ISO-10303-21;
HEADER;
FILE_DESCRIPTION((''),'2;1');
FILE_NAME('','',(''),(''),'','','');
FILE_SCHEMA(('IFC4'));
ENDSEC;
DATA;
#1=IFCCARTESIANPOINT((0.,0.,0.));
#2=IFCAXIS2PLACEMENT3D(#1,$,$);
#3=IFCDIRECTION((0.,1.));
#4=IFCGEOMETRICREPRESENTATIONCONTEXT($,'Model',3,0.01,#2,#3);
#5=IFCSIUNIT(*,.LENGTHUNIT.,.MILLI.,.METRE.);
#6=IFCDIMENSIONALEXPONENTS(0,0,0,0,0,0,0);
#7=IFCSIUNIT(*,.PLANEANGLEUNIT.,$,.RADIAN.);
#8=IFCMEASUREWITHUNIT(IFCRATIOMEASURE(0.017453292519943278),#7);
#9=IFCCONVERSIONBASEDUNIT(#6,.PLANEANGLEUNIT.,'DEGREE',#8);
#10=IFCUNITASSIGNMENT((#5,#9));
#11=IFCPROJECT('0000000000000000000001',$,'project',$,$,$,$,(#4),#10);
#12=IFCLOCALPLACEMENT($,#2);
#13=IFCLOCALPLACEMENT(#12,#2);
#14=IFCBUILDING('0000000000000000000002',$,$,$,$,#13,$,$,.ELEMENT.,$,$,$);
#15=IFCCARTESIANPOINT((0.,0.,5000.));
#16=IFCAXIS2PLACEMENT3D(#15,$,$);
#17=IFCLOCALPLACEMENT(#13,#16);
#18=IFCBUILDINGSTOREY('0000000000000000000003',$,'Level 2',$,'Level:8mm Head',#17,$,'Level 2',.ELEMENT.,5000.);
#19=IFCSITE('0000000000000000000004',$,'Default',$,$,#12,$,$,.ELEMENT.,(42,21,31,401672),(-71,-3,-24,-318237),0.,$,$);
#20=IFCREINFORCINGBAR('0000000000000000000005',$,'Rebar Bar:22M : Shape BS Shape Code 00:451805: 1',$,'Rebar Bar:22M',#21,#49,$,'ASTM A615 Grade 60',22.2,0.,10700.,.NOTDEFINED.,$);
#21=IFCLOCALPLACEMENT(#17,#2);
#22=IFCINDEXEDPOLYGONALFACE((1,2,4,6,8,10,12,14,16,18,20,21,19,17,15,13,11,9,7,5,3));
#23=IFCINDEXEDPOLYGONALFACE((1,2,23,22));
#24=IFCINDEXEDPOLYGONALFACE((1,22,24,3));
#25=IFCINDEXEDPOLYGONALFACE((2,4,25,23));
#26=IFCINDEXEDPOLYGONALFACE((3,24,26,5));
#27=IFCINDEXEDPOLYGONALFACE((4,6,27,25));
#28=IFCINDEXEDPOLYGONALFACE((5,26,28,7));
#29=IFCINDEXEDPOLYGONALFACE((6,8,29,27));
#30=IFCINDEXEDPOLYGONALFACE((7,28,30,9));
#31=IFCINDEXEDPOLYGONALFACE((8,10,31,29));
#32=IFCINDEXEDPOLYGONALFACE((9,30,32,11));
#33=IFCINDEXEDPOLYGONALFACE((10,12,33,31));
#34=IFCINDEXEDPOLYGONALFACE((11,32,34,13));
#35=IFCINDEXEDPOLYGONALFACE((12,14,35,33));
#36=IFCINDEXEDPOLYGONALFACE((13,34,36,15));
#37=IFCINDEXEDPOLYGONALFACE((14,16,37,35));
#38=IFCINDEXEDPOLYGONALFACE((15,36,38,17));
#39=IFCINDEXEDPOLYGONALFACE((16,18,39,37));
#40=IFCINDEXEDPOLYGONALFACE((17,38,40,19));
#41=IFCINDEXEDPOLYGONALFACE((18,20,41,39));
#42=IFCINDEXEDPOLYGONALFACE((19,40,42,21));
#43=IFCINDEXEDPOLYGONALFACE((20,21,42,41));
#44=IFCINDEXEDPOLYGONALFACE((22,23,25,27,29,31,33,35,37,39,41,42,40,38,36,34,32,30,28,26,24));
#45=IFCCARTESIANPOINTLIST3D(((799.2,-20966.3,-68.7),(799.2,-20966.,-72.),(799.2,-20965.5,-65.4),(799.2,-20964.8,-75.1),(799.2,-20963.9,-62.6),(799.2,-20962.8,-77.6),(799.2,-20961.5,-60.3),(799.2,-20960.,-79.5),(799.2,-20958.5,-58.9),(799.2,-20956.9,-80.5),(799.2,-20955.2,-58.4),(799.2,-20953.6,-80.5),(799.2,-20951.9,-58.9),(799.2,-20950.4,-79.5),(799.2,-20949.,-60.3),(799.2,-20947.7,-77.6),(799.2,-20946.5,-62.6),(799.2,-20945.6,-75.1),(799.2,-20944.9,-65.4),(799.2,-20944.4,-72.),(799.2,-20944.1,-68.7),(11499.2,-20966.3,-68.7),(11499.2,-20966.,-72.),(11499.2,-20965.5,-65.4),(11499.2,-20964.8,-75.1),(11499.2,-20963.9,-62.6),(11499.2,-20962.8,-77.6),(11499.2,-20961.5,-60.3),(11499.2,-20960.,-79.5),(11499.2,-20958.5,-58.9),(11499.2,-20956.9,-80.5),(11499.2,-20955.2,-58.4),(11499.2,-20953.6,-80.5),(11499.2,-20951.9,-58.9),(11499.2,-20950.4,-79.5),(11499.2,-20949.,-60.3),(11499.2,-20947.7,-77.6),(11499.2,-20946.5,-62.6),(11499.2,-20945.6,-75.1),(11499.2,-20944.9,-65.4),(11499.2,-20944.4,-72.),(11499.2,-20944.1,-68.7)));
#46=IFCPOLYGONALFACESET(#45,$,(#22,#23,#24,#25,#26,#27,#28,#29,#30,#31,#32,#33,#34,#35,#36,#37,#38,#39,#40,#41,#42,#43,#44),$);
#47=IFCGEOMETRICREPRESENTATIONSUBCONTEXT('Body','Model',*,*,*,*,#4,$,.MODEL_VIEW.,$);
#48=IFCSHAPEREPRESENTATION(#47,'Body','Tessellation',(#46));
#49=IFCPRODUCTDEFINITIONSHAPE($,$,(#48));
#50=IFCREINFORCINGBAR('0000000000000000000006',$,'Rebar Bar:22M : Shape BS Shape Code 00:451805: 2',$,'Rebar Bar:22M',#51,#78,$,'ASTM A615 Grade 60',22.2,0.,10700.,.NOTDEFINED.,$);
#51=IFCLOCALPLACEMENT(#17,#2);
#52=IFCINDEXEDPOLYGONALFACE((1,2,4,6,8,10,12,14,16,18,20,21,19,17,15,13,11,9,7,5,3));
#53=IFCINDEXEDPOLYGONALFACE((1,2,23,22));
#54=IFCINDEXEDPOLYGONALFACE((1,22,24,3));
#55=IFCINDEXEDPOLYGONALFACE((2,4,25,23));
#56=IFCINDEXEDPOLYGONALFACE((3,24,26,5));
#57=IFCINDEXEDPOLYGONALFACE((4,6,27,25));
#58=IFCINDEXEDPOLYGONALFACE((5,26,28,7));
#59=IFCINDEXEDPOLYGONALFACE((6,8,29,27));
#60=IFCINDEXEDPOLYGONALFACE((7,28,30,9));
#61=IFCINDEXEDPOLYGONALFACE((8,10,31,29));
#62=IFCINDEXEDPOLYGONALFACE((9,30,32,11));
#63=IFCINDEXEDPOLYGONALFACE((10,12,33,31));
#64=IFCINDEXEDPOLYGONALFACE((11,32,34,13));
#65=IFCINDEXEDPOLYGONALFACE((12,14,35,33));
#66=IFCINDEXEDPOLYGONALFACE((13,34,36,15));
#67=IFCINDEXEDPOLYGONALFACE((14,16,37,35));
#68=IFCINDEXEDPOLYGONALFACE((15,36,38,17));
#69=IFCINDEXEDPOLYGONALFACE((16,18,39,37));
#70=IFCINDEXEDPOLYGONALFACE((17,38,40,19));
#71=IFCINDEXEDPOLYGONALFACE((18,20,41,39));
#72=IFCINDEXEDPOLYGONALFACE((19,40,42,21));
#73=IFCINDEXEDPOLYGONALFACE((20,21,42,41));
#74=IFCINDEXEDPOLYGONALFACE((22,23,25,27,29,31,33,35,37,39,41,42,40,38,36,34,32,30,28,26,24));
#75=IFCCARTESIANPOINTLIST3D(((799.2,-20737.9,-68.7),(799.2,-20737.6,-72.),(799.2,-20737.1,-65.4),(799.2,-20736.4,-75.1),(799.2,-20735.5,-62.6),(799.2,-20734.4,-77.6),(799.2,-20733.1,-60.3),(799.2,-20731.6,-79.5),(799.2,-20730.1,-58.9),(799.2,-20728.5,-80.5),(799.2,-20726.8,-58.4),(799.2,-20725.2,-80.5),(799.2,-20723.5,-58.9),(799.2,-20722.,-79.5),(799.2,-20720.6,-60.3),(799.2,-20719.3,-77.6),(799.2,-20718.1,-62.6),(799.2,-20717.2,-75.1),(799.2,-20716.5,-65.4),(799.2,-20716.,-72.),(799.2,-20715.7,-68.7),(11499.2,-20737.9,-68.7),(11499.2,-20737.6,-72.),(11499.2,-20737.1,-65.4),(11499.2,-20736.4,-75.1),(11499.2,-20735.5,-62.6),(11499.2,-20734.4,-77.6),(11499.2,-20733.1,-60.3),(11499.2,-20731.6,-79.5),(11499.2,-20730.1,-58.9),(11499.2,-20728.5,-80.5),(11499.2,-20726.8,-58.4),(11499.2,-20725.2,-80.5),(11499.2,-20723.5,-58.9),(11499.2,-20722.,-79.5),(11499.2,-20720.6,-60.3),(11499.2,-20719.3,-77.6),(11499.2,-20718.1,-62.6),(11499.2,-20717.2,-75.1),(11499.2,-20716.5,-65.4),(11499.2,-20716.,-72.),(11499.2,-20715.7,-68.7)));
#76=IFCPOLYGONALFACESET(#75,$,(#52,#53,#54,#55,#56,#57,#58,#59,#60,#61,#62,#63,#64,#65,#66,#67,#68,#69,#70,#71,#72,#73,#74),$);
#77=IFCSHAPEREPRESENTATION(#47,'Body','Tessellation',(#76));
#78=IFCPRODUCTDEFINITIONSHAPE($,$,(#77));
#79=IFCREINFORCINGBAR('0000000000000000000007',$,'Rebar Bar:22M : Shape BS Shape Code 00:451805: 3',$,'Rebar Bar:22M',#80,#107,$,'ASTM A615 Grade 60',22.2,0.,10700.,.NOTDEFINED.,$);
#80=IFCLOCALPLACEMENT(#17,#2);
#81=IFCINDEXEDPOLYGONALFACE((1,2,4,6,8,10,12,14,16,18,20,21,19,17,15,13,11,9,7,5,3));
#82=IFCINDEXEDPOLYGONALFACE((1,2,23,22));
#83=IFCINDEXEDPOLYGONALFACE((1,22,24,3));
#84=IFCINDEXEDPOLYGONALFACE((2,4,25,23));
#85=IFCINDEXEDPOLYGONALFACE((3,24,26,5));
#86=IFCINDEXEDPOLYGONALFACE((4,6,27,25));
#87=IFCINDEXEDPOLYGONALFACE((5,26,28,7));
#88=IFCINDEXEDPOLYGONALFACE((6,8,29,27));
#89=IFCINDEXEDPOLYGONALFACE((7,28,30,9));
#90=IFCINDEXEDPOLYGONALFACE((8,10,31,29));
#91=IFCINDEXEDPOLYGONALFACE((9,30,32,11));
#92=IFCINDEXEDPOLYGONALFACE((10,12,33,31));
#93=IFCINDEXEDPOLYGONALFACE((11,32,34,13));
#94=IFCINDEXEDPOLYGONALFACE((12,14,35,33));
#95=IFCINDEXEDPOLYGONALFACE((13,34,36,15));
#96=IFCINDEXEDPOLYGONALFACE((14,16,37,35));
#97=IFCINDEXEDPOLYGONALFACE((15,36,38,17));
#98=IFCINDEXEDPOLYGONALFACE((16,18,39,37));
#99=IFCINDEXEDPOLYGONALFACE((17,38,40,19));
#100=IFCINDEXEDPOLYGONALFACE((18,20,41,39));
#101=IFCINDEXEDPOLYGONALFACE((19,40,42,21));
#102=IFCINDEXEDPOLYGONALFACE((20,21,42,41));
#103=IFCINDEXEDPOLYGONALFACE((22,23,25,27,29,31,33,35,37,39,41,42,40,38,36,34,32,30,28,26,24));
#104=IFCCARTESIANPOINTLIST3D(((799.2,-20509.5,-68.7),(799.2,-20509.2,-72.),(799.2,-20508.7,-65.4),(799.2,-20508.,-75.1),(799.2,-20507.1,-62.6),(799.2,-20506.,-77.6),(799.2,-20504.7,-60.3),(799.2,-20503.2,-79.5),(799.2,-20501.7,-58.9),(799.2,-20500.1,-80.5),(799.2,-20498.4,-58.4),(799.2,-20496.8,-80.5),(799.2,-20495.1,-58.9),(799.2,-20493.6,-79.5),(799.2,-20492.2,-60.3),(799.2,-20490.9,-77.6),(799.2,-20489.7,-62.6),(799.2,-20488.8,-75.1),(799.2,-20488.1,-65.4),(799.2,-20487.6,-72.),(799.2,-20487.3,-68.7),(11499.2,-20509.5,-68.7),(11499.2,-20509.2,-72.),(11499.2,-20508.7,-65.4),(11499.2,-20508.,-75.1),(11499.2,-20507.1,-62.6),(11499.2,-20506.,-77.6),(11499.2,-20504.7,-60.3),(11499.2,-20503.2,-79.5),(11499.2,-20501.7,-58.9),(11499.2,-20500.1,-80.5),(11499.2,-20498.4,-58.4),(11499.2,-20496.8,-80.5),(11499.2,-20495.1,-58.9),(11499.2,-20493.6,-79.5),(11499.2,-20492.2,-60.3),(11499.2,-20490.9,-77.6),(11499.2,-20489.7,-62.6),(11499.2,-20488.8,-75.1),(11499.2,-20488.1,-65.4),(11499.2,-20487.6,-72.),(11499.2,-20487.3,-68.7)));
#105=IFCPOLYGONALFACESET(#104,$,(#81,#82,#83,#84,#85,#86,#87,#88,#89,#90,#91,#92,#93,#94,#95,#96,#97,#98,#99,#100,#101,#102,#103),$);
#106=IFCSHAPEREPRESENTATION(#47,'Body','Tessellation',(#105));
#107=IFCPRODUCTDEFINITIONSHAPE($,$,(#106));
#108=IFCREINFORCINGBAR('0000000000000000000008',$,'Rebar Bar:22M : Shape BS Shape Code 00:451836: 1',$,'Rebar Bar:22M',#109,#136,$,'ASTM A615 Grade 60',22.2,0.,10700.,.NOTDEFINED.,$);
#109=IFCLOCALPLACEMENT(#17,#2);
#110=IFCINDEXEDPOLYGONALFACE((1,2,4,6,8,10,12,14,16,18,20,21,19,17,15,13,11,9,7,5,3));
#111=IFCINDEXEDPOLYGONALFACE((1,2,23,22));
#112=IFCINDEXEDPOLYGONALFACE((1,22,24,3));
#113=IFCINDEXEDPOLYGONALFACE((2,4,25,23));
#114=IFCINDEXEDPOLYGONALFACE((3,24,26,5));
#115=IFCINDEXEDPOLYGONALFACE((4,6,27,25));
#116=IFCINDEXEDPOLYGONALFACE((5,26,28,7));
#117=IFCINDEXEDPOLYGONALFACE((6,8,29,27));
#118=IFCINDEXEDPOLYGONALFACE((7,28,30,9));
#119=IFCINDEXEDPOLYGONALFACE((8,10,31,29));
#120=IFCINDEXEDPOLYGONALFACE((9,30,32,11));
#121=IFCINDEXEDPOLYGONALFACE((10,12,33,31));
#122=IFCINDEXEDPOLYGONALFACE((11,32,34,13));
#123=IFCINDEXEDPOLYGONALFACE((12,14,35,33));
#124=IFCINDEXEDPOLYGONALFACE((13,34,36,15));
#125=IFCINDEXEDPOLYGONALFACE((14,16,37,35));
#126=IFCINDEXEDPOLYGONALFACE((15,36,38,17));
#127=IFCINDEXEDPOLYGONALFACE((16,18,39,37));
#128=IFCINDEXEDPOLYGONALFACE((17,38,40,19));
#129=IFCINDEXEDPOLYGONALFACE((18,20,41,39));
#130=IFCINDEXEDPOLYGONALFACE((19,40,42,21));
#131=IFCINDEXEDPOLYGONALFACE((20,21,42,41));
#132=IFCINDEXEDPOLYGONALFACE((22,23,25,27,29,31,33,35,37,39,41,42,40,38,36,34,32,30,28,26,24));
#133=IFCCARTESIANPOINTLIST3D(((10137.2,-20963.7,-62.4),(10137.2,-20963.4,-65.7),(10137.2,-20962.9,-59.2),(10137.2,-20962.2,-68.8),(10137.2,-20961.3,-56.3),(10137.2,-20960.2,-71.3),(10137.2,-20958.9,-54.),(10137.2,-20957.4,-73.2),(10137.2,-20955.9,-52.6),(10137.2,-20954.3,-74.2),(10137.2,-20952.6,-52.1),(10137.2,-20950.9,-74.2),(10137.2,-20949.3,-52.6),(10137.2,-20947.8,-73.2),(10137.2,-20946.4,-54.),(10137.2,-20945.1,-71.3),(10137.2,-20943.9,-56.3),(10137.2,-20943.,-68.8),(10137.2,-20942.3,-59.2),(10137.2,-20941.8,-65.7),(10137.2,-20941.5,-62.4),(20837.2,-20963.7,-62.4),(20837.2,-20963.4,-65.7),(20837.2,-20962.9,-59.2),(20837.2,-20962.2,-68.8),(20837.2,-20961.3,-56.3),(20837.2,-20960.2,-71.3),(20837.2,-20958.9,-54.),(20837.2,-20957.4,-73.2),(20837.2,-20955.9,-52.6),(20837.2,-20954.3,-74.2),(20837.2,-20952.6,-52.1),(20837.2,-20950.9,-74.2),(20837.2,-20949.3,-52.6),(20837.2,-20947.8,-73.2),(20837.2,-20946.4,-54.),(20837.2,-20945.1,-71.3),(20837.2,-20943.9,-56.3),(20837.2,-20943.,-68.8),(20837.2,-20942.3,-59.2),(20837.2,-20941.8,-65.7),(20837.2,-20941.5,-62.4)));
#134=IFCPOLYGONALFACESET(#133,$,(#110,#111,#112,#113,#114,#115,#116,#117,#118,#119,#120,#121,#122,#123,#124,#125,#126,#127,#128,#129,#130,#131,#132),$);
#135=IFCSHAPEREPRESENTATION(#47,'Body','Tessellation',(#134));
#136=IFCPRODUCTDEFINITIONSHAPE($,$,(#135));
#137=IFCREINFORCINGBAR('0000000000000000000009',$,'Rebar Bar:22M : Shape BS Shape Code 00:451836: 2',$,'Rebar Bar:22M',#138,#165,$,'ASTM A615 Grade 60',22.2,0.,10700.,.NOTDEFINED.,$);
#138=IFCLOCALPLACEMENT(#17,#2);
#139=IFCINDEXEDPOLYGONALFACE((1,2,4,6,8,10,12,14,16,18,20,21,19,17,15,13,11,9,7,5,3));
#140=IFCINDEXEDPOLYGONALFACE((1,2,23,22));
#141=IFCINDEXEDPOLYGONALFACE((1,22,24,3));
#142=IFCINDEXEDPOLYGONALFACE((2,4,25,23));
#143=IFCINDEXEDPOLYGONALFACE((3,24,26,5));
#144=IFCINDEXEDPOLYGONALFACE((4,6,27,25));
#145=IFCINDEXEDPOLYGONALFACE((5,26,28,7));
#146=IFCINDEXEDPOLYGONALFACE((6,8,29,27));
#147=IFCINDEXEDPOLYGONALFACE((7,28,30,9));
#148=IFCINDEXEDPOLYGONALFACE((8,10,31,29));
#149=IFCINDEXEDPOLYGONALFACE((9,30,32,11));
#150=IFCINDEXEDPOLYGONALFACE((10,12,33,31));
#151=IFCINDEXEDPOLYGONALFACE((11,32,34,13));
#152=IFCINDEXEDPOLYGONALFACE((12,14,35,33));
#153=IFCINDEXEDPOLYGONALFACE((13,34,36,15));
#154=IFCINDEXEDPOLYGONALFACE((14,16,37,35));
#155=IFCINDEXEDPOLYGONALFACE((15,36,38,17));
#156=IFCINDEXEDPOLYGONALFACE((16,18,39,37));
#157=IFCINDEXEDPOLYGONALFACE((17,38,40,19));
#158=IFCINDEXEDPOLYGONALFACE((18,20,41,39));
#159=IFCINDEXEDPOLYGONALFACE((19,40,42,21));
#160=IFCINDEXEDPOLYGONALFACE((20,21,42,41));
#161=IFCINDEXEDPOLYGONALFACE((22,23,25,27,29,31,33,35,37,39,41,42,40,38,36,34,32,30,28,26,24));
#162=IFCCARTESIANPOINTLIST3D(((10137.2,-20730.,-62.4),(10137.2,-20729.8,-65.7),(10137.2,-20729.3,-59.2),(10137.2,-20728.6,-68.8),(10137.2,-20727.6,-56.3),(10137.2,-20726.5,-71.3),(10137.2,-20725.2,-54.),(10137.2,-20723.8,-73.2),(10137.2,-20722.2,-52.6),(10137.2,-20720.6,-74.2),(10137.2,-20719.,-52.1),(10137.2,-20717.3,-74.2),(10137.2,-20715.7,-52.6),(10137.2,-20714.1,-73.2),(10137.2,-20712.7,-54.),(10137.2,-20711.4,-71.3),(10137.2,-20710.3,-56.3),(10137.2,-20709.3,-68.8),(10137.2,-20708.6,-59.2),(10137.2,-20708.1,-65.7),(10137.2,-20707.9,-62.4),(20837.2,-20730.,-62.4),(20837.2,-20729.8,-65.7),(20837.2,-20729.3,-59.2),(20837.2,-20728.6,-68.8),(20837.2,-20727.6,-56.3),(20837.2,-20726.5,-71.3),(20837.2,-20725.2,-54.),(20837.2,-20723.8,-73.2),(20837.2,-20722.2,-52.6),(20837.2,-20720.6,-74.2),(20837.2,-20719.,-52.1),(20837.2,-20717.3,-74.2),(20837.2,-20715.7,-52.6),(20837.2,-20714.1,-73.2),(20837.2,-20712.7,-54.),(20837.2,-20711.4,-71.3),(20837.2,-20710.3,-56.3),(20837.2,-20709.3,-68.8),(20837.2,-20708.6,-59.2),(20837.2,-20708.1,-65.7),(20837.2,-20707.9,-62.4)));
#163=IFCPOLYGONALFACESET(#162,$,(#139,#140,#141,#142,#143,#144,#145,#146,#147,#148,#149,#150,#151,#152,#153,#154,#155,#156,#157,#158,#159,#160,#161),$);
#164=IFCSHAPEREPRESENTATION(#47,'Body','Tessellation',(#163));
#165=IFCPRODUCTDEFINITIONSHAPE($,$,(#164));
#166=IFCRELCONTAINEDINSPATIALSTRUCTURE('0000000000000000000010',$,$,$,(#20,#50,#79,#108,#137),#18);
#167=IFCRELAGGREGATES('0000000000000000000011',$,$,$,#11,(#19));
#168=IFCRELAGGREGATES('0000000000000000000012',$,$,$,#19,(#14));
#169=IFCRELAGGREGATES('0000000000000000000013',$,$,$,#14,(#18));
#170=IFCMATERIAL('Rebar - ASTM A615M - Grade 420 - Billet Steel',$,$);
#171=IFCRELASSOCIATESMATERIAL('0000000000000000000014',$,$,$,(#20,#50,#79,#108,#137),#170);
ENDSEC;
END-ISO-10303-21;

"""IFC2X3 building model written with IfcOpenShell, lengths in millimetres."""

from ifc_helpers import new_model, entity, si_unit, converted_unit, direction, frame, origin, place, context, subcontext, project, spatial, material, element, save


model = new_model("IFC2X3")

# Units and contexts
model_context = context("Model", 3, precision=0.01, world=origin(), true_north=direction((0.0, 1.0)))
body_context = subcontext(model_context, "Body", "Model", "MODEL_VIEW")
ifc_project = project(units=[si_unit("LENGTHUNIT", "METRE", prefix="MILLI"), converted_unit("PLANEANGLEUNIT", "DEGREE", entity("IfcRatioMeasure", 0.017453292519943278), si_unit("PLANEANGLEUNIT", "RADIAN"), dimensions=[0, 0, 0, 0, 0, 0, 0])], contexts=[model_context])

# Site, building, storey
site_placement = place(None, origin())
site = spatial("IfcSite", under=ifc_project, at=site_placement, Name="Default", CompositionType="ELEMENT", RefLatitude=(42, 21, 31, 401672), RefLongitude=(-71, -3, -24, -318237), RefElevation=0.0)
building_placement = place(site_placement, origin())
building = spatial("IfcBuilding", under=site, at=building_placement, CompositionType="ELEMENT")
storey_placement = place(building_placement, frame((0.0, 0.0, 5000.0)))
storey = spatial("IfcBuildingStorey", under=building, at=storey_placement, Name="Level 2", ObjectType="Level:8mm Head", LongName="Level 2", CompositionType="ELEMENT", Elevation=5000.0)

# Reinforcing bars
ifc_material_1 = material(Name="Rebar - ASTM A615M - Grade 420 - Billet Steel")
reinforcing_bar_1_placement = place(storey_placement, origin())
element("IfcReinforcingBar", 1, at=reinforcing_bar_1_placement, inside=storey, material=ifc_material_1, Name="Rebar Bar:22M : Shape BS Shape Code 00:451805: 1", SteelGrade="ASTM A615 Grade 60", ObjectType="Rebar Bar:22M", BarLength=10700.0, BarRole="NOTDEFINED", CrossSectionArea=0.0, NominalDiameter=22.2, context=body_context, shape_type="AdvancedSweptSolid", body=[
    entity("IfcSweptDiskSolid", entity("IfcCompositeCurve", [entity("IfcCompositeCurveSegment", "CONTINUOUS", True, entity("IfcPolyline", [entity("IfcCartesianPoint", [799.2, -20955.2, -69.5]), entity("IfcCartesianPoint", [11499.2, -20955.2, -69.5])]))], False), 11.1, None, 0.0, 1.0),
])
reinforcing_bar_2_placement = place(storey_placement, origin())
element("IfcReinforcingBar", 2, at=reinforcing_bar_2_placement, inside=storey, material=ifc_material_1, Name="Rebar Bar:22M : Shape BS Shape Code 00:451805: 2", SteelGrade="ASTM A615 Grade 60", ObjectType="Rebar Bar:22M", BarLength=10700.0, BarRole="NOTDEFINED", CrossSectionArea=0.0, NominalDiameter=22.2, context=body_context, shape_type="AdvancedSweptSolid", body=[
    entity("IfcSweptDiskSolid", entity("IfcCompositeCurve", [entity("IfcCompositeCurveSegment", "CONTINUOUS", True, entity("IfcPolyline", [entity("IfcCartesianPoint", [799.2, -20726.8, -69.5]), entity("IfcCartesianPoint", [11499.2, -20726.8, -69.5])]))], False), 11.1, None, 0.0, 1.0),
])
reinforcing_bar_3_placement = place(storey_placement, origin())
element("IfcReinforcingBar", 3, at=reinforcing_bar_3_placement, inside=storey, material=ifc_material_1, Name="Rebar Bar:22M : Shape BS Shape Code 00:451805: 3", SteelGrade="ASTM A615 Grade 60", ObjectType="Rebar Bar:22M", BarLength=10700.0, BarRole="NOTDEFINED", CrossSectionArea=0.0, NominalDiameter=22.2, context=body_context, shape_type="AdvancedSweptSolid", body=[
    entity("IfcSweptDiskSolid", entity("IfcCompositeCurve", [entity("IfcCompositeCurveSegment", "CONTINUOUS", True, entity("IfcPolyline", [entity("IfcCartesianPoint", [799.2, -20498.4, -69.5]), entity("IfcCartesianPoint", [11499.2, -20498.4, -69.5])]))], False), 11.1, None, 0.0, 1.0),
])
reinforcing_bar_4_placement = place(storey_placement, origin())
element("IfcReinforcingBar", 4, at=reinforcing_bar_4_placement, inside=storey, material=ifc_material_1, Name="Rebar Bar:22M : Shape BS Shape Code 00:451836: 1", SteelGrade="ASTM A615 Grade 60", ObjectType="Rebar Bar:22M", BarLength=10700.0, BarRole="NOTDEFINED", CrossSectionArea=0.0, NominalDiameter=22.2, context=body_context, shape_type="AdvancedSweptSolid", body=[
    entity("IfcSweptDiskSolid", entity("IfcCompositeCurve", [entity("IfcCompositeCurveSegment", "CONTINUOUS", True, entity("IfcPolyline", [entity("IfcCartesianPoint", [10137.2, -20952.6, -63.2]), entity("IfcCartesianPoint", [20837.2, -20952.6, -63.2])]))], False), 11.1, None, 0.0, 1.0),
])
reinforcing_bar_5_placement = place(storey_placement, origin())
element("IfcReinforcingBar", 5, at=reinforcing_bar_5_placement, inside=storey, material=ifc_material_1, Name="Rebar Bar:22M : Shape BS Shape Code 00:451836: 2", SteelGrade="ASTM A615 Grade 60", ObjectType="Rebar Bar:22M", BarLength=10700.0, BarRole="NOTDEFINED", CrossSectionArea=0.0, NominalDiameter=22.2, context=body_context, shape_type="AdvancedSweptSolid", body=[
    entity("IfcSweptDiskSolid", entity("IfcCompositeCurve", [entity("IfcCompositeCurveSegment", "CONTINUOUS", True, entity("IfcPolyline", [entity("IfcCartesianPoint", [10137.2, -20719.0, -63.2]), entity("IfcCartesianPoint", [20837.2, -20719.0, -63.2])]))], False), 11.1, None, 0.0, 1.0),
])

save(model, "model.ifc")
